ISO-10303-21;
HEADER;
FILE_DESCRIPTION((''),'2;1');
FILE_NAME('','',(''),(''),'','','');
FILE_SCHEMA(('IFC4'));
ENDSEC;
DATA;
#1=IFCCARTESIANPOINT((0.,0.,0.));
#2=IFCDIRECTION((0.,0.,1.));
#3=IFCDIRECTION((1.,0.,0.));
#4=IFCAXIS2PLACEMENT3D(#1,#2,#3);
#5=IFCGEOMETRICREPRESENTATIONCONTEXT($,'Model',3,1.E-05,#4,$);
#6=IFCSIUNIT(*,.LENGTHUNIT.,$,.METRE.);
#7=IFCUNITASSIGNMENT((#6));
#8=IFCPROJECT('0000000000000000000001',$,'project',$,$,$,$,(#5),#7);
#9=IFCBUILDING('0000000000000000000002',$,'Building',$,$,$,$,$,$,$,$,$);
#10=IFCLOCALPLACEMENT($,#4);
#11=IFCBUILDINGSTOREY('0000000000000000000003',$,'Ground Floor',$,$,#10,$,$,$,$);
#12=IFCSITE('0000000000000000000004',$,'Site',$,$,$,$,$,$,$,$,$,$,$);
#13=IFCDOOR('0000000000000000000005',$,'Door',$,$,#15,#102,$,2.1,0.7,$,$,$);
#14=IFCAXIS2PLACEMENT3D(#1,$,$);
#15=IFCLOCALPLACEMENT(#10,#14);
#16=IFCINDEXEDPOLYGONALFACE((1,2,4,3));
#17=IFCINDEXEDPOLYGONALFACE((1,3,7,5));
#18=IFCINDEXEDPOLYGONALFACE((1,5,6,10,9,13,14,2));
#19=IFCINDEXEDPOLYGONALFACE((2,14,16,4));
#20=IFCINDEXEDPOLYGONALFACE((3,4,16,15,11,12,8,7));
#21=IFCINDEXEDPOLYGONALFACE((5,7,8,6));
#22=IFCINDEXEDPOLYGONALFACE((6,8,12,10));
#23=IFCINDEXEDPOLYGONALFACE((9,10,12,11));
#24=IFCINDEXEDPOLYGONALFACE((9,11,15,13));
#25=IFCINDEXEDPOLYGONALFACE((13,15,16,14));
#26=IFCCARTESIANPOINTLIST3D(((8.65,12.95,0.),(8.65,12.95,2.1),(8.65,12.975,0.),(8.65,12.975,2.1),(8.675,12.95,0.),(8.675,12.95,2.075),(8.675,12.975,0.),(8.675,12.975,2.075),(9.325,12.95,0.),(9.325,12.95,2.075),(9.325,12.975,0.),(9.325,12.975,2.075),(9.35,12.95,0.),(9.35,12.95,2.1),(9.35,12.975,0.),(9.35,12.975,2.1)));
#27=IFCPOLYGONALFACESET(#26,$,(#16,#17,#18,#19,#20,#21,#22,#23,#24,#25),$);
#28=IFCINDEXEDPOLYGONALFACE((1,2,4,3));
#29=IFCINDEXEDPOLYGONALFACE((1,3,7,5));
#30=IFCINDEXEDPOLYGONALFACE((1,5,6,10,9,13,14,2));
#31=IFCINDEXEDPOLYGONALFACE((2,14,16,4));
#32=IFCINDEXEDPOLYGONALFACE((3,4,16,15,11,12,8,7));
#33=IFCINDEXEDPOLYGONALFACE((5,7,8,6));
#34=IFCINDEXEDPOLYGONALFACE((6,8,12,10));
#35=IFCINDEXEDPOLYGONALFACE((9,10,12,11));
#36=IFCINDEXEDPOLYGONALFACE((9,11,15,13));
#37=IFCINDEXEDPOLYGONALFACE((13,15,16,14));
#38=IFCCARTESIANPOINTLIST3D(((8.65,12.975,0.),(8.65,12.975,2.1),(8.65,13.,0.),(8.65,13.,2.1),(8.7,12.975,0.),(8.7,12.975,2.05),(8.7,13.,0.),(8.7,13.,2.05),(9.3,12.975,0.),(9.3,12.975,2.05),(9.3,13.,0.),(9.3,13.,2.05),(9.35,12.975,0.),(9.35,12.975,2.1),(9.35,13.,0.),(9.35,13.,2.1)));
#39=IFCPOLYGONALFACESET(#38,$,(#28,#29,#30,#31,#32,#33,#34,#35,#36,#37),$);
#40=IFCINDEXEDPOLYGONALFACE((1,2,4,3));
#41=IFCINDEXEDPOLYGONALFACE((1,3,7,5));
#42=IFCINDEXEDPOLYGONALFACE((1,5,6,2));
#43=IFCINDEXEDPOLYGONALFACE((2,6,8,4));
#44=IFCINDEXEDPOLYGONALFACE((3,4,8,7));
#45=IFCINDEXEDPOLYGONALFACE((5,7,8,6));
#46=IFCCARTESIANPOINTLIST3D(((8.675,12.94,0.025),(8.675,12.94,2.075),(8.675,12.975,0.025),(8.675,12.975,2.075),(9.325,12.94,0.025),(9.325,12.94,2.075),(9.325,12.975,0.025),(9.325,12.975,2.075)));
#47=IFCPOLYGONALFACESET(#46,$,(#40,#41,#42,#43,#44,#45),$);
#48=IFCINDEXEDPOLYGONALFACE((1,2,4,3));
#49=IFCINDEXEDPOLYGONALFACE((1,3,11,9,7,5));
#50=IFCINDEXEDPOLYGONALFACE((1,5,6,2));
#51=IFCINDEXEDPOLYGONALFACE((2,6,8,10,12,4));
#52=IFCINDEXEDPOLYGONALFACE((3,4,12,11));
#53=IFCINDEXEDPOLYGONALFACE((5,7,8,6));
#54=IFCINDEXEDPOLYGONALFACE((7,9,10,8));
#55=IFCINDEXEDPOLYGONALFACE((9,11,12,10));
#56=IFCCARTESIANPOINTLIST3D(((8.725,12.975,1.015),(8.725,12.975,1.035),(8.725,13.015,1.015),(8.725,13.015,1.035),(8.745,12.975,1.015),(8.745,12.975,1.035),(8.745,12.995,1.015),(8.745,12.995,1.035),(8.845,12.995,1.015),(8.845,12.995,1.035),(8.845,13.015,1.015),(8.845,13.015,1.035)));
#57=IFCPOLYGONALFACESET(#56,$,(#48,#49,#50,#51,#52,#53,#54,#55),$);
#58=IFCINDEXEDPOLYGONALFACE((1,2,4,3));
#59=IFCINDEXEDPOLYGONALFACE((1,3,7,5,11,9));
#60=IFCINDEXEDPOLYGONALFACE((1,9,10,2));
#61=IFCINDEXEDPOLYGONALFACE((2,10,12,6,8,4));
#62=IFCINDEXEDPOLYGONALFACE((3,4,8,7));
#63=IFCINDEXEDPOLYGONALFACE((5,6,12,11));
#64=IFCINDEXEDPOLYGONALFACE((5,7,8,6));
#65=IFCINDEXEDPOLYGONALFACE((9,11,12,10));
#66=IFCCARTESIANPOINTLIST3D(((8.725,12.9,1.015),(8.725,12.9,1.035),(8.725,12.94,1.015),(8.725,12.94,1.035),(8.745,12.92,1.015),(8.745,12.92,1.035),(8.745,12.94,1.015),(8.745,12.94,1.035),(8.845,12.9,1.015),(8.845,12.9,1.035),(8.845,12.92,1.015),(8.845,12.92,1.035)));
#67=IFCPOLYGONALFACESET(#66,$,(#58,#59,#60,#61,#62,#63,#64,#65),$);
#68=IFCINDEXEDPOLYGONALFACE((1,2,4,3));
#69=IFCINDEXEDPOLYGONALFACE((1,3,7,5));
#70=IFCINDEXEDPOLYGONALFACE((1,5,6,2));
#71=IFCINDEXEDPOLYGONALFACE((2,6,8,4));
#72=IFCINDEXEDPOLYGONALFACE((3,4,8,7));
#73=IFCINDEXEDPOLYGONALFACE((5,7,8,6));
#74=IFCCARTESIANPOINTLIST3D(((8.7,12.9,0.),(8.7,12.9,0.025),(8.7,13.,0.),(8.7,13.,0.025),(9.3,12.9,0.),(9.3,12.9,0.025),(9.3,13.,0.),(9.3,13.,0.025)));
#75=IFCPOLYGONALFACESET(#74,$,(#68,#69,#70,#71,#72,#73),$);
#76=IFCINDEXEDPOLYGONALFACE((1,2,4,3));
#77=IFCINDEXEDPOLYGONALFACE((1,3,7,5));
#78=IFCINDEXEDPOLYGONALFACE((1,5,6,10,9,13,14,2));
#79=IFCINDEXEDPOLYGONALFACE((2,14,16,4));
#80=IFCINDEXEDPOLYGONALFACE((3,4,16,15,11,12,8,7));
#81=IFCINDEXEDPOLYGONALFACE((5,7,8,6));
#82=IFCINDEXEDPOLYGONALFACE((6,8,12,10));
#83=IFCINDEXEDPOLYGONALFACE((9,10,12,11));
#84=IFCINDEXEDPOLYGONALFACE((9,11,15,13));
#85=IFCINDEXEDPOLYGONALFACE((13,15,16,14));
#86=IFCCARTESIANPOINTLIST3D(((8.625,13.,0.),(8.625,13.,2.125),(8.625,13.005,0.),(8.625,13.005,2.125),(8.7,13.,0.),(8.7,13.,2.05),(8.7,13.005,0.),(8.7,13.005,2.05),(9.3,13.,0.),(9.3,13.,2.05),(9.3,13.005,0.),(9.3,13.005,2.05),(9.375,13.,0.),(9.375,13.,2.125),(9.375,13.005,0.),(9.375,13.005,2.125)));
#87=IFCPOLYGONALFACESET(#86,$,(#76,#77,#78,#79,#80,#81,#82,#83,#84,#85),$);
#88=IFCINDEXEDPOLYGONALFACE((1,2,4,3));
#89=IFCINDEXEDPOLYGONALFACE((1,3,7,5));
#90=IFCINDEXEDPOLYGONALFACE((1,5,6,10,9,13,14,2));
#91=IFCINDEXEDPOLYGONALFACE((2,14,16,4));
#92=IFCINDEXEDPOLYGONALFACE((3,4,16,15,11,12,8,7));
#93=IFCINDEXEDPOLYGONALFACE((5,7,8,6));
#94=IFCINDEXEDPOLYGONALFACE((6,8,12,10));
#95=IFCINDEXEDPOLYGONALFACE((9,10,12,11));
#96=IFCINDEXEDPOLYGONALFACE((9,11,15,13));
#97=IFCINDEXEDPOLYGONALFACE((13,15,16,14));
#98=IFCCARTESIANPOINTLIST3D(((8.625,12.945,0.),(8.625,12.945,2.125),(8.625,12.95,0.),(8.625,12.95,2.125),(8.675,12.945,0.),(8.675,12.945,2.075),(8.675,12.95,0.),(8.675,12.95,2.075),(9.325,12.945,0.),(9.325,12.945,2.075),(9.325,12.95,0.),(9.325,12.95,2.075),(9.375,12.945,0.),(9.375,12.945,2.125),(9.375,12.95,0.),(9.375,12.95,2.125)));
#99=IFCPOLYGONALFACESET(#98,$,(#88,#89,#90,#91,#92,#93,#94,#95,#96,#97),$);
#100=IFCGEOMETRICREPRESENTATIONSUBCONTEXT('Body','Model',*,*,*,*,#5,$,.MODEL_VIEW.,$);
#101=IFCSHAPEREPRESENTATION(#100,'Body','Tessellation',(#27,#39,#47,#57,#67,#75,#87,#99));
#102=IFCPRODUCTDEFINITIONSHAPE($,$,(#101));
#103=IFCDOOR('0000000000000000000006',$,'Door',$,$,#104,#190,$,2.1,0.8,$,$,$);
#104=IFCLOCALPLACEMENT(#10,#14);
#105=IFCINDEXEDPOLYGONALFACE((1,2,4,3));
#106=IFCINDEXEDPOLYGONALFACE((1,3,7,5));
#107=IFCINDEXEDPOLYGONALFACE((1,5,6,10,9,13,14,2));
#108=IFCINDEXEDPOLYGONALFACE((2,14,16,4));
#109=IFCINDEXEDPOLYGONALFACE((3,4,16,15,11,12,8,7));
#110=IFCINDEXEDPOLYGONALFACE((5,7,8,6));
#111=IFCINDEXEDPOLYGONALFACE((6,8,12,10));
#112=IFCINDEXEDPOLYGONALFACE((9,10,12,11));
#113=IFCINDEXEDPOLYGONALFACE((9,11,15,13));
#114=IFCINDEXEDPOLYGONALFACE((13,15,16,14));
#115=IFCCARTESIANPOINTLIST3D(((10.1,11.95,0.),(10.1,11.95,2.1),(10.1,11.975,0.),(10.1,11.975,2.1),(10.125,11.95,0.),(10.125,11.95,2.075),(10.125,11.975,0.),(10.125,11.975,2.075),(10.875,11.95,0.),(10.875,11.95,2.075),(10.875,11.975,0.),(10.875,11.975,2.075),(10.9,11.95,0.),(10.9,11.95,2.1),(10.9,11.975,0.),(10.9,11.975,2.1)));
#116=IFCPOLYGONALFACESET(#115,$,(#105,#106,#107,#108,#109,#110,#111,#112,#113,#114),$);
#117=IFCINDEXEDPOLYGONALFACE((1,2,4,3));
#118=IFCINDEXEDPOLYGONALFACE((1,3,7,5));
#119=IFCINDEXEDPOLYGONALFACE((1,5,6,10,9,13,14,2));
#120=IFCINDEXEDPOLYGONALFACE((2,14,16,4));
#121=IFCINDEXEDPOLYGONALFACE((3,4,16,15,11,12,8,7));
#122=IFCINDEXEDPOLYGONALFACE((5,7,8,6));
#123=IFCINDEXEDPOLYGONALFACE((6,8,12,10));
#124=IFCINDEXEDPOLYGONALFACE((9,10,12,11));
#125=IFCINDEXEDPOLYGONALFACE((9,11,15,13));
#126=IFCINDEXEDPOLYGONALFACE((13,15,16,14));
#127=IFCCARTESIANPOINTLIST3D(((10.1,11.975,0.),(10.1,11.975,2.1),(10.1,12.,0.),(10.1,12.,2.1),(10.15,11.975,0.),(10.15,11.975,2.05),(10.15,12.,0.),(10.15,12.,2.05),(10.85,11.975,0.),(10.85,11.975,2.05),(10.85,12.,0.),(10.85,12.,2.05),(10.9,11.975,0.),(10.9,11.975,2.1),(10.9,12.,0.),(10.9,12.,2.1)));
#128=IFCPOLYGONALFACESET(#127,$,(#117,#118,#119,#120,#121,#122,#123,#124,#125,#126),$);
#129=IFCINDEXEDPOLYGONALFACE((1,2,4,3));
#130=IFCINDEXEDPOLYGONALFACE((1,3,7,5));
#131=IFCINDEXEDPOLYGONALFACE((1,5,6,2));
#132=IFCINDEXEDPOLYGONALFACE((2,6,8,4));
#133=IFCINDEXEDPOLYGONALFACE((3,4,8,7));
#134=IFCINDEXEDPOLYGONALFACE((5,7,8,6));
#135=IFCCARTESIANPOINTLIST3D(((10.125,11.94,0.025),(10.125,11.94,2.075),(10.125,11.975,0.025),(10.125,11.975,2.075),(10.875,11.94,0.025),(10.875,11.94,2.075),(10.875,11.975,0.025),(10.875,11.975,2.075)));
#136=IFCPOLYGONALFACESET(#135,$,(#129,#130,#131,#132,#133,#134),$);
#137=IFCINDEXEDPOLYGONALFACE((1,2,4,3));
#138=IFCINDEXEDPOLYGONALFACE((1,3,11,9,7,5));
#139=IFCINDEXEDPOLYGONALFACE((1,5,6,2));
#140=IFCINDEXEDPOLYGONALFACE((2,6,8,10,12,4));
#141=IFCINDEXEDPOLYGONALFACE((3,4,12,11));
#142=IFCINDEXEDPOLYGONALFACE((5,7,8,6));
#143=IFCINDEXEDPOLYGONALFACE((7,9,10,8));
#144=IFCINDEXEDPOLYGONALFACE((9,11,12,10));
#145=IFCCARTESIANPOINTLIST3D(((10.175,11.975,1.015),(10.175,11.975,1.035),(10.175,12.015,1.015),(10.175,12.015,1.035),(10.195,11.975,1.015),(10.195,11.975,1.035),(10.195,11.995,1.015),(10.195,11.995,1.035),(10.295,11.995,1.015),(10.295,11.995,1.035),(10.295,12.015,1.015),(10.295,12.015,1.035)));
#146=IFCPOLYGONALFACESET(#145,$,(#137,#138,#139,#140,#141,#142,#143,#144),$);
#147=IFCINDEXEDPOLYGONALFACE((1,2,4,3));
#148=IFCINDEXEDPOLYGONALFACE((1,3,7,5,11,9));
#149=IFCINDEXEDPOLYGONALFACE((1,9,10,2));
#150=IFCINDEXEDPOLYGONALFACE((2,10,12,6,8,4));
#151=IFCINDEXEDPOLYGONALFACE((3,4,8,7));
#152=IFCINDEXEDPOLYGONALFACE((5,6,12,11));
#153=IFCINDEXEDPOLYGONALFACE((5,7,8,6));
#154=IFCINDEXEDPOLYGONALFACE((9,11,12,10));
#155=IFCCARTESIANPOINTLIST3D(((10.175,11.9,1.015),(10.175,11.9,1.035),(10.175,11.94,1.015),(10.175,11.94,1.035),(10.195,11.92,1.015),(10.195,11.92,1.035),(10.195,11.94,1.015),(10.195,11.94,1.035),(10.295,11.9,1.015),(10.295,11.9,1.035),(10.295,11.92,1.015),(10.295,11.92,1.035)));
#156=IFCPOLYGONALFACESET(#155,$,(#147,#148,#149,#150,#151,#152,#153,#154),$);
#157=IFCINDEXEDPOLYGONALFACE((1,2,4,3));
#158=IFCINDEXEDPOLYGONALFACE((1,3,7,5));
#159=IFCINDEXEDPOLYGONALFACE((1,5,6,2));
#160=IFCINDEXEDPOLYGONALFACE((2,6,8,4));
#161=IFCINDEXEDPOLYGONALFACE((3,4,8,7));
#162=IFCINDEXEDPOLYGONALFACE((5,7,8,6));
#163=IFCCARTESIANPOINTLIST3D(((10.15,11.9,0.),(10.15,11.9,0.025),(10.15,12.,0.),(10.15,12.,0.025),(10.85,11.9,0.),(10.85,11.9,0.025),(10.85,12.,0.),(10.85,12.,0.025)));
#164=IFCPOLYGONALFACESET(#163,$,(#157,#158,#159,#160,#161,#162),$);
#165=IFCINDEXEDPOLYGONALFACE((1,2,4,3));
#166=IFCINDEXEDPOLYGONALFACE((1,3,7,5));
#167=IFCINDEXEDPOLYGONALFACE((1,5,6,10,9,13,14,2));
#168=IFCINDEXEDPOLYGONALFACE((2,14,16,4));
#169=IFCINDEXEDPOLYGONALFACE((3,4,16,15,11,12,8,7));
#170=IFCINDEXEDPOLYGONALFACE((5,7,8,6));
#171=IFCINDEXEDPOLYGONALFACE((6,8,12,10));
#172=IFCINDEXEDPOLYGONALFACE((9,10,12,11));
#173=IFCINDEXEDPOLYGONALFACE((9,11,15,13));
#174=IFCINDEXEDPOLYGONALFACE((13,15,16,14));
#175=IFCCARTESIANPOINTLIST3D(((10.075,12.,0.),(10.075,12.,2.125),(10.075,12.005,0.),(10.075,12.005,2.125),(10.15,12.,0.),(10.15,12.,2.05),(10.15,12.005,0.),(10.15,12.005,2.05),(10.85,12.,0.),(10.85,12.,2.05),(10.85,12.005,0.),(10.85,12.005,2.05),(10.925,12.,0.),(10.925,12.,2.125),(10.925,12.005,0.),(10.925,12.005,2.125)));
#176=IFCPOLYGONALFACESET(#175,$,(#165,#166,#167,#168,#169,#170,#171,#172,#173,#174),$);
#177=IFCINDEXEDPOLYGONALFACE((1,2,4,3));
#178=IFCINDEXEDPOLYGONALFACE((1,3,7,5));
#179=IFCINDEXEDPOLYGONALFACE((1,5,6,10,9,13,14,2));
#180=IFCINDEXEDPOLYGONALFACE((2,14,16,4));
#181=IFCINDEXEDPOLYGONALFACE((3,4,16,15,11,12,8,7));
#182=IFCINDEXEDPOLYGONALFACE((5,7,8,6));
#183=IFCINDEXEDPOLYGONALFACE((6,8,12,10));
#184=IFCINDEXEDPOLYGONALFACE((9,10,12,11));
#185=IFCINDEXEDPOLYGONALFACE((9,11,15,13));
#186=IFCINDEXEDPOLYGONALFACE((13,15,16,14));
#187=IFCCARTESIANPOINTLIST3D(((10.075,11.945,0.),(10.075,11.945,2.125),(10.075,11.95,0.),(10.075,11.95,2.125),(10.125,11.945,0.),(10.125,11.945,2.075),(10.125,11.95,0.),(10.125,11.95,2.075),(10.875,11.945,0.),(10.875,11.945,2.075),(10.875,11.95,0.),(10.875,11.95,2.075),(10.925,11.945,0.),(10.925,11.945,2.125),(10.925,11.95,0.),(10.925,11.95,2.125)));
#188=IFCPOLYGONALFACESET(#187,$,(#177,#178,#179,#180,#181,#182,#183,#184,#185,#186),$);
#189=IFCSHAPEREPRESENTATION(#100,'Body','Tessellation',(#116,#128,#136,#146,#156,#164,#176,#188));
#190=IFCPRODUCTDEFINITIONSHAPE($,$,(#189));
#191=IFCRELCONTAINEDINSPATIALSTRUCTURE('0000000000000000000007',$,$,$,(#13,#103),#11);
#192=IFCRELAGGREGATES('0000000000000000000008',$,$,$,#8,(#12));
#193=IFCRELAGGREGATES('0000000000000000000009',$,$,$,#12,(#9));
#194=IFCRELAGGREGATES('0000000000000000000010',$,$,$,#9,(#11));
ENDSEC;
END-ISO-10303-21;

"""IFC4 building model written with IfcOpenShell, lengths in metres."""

from ifc_helpers import new_model, si_unit, frame, origin_with_axes, place, context, subcontext, project, spatial, line, indexed_curve, outline, extrude, element, save


model = new_model("IFC4")

# Units and contexts
model_context = context("Model", 3, precision=1e-05, world=origin_with_axes())
body_context = subcontext(model_context, "Body", "Model", "MODEL_VIEW")
ifc_project = project(units=[si_unit("LENGTHUNIT", "METRE")], contexts=[model_context])

# Site, building, storey
site = spatial("IfcSite", under=ifc_project, Name="Site")
building = spatial("IfcBuilding", under=site, Name="Building")
storey_placement = place(None, origin_with_axes())
storey = spatial("IfcBuildingStorey", under=building, at=storey_placement, Name="Ground Floor")

# Doors
door_1_placement = place(storey_placement, frame((9.35, 13.0, 0.0), z_axis=(0.0, 0.0, 1.0), x_axis=(-1.0, 0.0, 0.0)))
element("IfcDoor", 1, at=door_1_placement, inside=storey, Name="Door", OverallHeight=2.1, OverallWidth=0.7, context=body_context, shape_type="SweptSolid", body=[
    extrude(outline(indexed_curve([(0.0, 0.0), (0.0, 2.1), (0.7, 2.1), (0.7, 0.0), (0.675, 0.0), (0.675, 2.075), (0.025, 2.075), (0.025, 0.0)], segments=[line(1, 2, 3, 4, 5, 6, 7, 8, 1)])), frame((0.0, 0.025, 0.0), z_axis=(0.0, -1.0, 0.0), x_axis=(1.0, 0.0, 0.0)), (0.0, 0.0, -1.0), 0.025),
    extrude(outline(indexed_curve([(0.0, 0.0), (0.0, 2.1), (0.7, 2.1), (0.7, 0.0), (0.65, 0.0), (0.65, 2.05), (0.05, 2.05), (0.05, 0.0)], segments=[line(1, 2, 3, 4, 5, 6, 7, 8, 1)])), frame((0.0, 0.0, 0.0), z_axis=(0.0, -1.0, 0.0), x_axis=(1.0, 0.0, 0.0)), (0.0, 0.0, -1.0), 0.025),
    extrude(outline(indexed_curve([(0.0, 0.0), (0.65, 0.0), (0.65, 0.035), (0.0, 0.035)], segments=[line(1, 2, 3, 4, 1)])), frame((0.025, 0.025, 0.025), z_axis=(0.0, 0.0, 1.0), x_axis=(1.0, 0.0, 0.0)), (0.0, 0.0, 1.0), 2.05),
    extrude(outline(indexed_curve([(0.0, 0.0), (0.0, -0.04), (-0.12, -0.04), (-0.12, -0.02), (-0.02, -0.02), (-0.02, 0.0)], segments=[line(1, 2, 3, 4, 5, 6, 1)])), frame((0.625, 0.025, 1.015), z_axis=(0.0, 0.0, 1.0), x_axis=(1.0, 0.0, 0.0)), (0.0, 0.0, 1.0), 0.02),
    extrude(outline(indexed_curve([(0.0, 0.0), (0.0, 0.04), (-0.12, 0.04), (-0.12, 0.02), (-0.02, 0.02), (-0.02, 0.0)], segments=[line(1, 2, 3, 4, 5, 6, 1)])), frame((0.625, 0.06, 1.015), z_axis=(0.0, 0.0, 1.0), x_axis=(1.0, 0.0, 0.0)), (0.0, 0.0, 1.0), 0.02),
    extrude(outline(indexed_curve([(0.0, 0.0), (0.6, 0.0), (0.6, 0.1), (0.0, 0.1)], segments=[line(1, 2, 3, 4, 1)])), frame((0.05, 0.0, 0.0), z_axis=(0.0, 0.0, 1.0), x_axis=(1.0, 0.0, 0.0)), (0.0, 0.0, 1.0), 0.025),
    extrude(outline(indexed_curve([(0.0, 0.0), (0.0, 2.125), (0.75, 2.125), (0.75, 0.0), (0.675, 0.0), (0.675, 2.05), (0.075, 2.05), (0.075, 0.0)], segments=[line(1, 2, 3, 4, 5, 6, 7, 8, 1)])), frame((-0.025, -0.005, 0.0), z_axis=(0.0, -1.0, 0.0), x_axis=(1.0, 0.0, 0.0)), (0.0, 0.0, -1.0), 0.005),
    extrude(outline(indexed_curve([(0.0, 0.0), (0.0, 2.125), (0.75, 2.125), (0.75, 0.0), (0.7, 0.0), (0.7, 2.075), (0.05, 2.075), (0.05, 0.0)], segments=[line(1, 2, 3, 4, 5, 6, 7, 8, 1)])), frame((-0.025, 0.05, 0.0), z_axis=(0.0, -1.0, 0.0), x_axis=(1.0, 0.0, 0.0)), (0.0, 0.0, -1.0), 0.005),
])
door_2_placement = place(storey_placement, frame((10.9, 12.0, 0.0), z_axis=(0.0, 0.0, 1.0), x_axis=(-1.0, 0.0, 0.0)))
element("IfcDoor", 2, at=door_2_placement, inside=storey, Name="Door", OverallHeight=2.1, OverallWidth=0.8, context=body_context, shape_type="SweptSolid", body=[
    extrude(outline(indexed_curve([(0.0, 0.0), (0.0, 2.1), (0.8, 2.1), (0.8, 0.0), (0.775, 0.0), (0.775, 2.075), (0.025, 2.075), (0.025, 0.0)], segments=[line(1, 2, 3, 4, 5, 6, 7, 8, 1)])), frame((0.0, 0.025, 0.0), z_axis=(0.0, -1.0, 0.0), x_axis=(1.0, 0.0, 0.0)), (0.0, 0.0, -1.0), 0.025),
    extrude(outline(indexed_curve([(0.0, 0.0), (0.0, 2.1), (0.8, 2.1), (0.8, 0.0), (0.75, 0.0), (0.75, 2.05), (0.05, 2.05), (0.05, 0.0)], segments=[line(1, 2, 3, 4, 5, 6, 7, 8, 1)])), frame((0.0, 0.0, 0.0), z_axis=(0.0, -1.0, 0.0), x_axis=(1.0, 0.0, 0.0)), (0.0, 0.0, -1.0), 0.025),
    extrude(outline(indexed_curve([(0.0, 0.0), (0.75, 0.0), (0.75, 0.035), (0.0, 0.035)], segments=[line(1, 2, 3, 4, 1)])), frame((0.025, 0.025, 0.025), z_axis=(0.0, 0.0, 1.0), x_axis=(1.0, 0.0, 0.0)), (0.0, 0.0, 1.0), 2.05),
    extrude(outline(indexed_curve([(0.0, 0.0), (0.0, -0.04), (-0.12, -0.04), (-0.12, -0.02), (-0.02, -0.02), (-0.02, 0.0)], segments=[line(1, 2, 3, 4, 5, 6, 1)])), frame((0.725, 0.025, 1.015), z_axis=(0.0, 0.0, 1.0), x_axis=(1.0, 0.0, 0.0)), (0.0, 0.0, 1.0), 0.02),
    extrude(outline(indexed_curve([(0.0, 0.0), (0.0, 0.04), (-0.12, 0.04), (-0.12, 0.02), (-0.02, 0.02), (-0.02, 0.0)], segments=[line(1, 2, 3, 4, 5, 6, 1)])), frame((0.725, 0.06, 1.015), z_axis=(0.0, 0.0, 1.0), x_axis=(1.0, 0.0, 0.0)), (0.0, 0.0, 1.0), 0.02),
    extrude(outline(indexed_curve([(0.0, 0.0), (0.7, 0.0), (0.7, 0.1), (0.0, 0.1)], segments=[line(1, 2, 3, 4, 1)])), frame((0.05, 0.0, 0.0), z_axis=(0.0, 0.0, 1.0), x_axis=(1.0, 0.0, 0.0)), (0.0, 0.0, 1.0), 0.025),
    extrude(outline(indexed_curve([(0.0, 0.0), (0.0, 2.125), (0.85, 2.125), (0.85, 0.0), (0.775, 0.0), (0.775, 2.05), (0.075, 2.05), (0.075, 0.0)], segments=[line(1, 2, 3, 4, 5, 6, 7, 8, 1)])), frame((-0.025, -0.005, 0.0), z_axis=(0.0, -1.0, 0.0), x_axis=(1.0, 0.0, 0.0)), (0.0, 0.0, -1.0), 0.005),
    extrude(outline(indexed_curve([(0.0, 0.0), (0.0, 2.125), (0.85, 2.125), (0.85, 0.0), (0.8, 0.0), (0.8, 2.075), (0.05, 2.075), (0.05, 0.0)], segments=[line(1, 2, 3, 4, 5, 6, 7, 8, 1)])), frame((-0.025, 0.05, 0.0), z_axis=(0.0, -1.0, 0.0), x_axis=(1.0, 0.0, 0.0)), (0.0, 0.0, -1.0), 0.005),
])

save(model, "model.ifc")
